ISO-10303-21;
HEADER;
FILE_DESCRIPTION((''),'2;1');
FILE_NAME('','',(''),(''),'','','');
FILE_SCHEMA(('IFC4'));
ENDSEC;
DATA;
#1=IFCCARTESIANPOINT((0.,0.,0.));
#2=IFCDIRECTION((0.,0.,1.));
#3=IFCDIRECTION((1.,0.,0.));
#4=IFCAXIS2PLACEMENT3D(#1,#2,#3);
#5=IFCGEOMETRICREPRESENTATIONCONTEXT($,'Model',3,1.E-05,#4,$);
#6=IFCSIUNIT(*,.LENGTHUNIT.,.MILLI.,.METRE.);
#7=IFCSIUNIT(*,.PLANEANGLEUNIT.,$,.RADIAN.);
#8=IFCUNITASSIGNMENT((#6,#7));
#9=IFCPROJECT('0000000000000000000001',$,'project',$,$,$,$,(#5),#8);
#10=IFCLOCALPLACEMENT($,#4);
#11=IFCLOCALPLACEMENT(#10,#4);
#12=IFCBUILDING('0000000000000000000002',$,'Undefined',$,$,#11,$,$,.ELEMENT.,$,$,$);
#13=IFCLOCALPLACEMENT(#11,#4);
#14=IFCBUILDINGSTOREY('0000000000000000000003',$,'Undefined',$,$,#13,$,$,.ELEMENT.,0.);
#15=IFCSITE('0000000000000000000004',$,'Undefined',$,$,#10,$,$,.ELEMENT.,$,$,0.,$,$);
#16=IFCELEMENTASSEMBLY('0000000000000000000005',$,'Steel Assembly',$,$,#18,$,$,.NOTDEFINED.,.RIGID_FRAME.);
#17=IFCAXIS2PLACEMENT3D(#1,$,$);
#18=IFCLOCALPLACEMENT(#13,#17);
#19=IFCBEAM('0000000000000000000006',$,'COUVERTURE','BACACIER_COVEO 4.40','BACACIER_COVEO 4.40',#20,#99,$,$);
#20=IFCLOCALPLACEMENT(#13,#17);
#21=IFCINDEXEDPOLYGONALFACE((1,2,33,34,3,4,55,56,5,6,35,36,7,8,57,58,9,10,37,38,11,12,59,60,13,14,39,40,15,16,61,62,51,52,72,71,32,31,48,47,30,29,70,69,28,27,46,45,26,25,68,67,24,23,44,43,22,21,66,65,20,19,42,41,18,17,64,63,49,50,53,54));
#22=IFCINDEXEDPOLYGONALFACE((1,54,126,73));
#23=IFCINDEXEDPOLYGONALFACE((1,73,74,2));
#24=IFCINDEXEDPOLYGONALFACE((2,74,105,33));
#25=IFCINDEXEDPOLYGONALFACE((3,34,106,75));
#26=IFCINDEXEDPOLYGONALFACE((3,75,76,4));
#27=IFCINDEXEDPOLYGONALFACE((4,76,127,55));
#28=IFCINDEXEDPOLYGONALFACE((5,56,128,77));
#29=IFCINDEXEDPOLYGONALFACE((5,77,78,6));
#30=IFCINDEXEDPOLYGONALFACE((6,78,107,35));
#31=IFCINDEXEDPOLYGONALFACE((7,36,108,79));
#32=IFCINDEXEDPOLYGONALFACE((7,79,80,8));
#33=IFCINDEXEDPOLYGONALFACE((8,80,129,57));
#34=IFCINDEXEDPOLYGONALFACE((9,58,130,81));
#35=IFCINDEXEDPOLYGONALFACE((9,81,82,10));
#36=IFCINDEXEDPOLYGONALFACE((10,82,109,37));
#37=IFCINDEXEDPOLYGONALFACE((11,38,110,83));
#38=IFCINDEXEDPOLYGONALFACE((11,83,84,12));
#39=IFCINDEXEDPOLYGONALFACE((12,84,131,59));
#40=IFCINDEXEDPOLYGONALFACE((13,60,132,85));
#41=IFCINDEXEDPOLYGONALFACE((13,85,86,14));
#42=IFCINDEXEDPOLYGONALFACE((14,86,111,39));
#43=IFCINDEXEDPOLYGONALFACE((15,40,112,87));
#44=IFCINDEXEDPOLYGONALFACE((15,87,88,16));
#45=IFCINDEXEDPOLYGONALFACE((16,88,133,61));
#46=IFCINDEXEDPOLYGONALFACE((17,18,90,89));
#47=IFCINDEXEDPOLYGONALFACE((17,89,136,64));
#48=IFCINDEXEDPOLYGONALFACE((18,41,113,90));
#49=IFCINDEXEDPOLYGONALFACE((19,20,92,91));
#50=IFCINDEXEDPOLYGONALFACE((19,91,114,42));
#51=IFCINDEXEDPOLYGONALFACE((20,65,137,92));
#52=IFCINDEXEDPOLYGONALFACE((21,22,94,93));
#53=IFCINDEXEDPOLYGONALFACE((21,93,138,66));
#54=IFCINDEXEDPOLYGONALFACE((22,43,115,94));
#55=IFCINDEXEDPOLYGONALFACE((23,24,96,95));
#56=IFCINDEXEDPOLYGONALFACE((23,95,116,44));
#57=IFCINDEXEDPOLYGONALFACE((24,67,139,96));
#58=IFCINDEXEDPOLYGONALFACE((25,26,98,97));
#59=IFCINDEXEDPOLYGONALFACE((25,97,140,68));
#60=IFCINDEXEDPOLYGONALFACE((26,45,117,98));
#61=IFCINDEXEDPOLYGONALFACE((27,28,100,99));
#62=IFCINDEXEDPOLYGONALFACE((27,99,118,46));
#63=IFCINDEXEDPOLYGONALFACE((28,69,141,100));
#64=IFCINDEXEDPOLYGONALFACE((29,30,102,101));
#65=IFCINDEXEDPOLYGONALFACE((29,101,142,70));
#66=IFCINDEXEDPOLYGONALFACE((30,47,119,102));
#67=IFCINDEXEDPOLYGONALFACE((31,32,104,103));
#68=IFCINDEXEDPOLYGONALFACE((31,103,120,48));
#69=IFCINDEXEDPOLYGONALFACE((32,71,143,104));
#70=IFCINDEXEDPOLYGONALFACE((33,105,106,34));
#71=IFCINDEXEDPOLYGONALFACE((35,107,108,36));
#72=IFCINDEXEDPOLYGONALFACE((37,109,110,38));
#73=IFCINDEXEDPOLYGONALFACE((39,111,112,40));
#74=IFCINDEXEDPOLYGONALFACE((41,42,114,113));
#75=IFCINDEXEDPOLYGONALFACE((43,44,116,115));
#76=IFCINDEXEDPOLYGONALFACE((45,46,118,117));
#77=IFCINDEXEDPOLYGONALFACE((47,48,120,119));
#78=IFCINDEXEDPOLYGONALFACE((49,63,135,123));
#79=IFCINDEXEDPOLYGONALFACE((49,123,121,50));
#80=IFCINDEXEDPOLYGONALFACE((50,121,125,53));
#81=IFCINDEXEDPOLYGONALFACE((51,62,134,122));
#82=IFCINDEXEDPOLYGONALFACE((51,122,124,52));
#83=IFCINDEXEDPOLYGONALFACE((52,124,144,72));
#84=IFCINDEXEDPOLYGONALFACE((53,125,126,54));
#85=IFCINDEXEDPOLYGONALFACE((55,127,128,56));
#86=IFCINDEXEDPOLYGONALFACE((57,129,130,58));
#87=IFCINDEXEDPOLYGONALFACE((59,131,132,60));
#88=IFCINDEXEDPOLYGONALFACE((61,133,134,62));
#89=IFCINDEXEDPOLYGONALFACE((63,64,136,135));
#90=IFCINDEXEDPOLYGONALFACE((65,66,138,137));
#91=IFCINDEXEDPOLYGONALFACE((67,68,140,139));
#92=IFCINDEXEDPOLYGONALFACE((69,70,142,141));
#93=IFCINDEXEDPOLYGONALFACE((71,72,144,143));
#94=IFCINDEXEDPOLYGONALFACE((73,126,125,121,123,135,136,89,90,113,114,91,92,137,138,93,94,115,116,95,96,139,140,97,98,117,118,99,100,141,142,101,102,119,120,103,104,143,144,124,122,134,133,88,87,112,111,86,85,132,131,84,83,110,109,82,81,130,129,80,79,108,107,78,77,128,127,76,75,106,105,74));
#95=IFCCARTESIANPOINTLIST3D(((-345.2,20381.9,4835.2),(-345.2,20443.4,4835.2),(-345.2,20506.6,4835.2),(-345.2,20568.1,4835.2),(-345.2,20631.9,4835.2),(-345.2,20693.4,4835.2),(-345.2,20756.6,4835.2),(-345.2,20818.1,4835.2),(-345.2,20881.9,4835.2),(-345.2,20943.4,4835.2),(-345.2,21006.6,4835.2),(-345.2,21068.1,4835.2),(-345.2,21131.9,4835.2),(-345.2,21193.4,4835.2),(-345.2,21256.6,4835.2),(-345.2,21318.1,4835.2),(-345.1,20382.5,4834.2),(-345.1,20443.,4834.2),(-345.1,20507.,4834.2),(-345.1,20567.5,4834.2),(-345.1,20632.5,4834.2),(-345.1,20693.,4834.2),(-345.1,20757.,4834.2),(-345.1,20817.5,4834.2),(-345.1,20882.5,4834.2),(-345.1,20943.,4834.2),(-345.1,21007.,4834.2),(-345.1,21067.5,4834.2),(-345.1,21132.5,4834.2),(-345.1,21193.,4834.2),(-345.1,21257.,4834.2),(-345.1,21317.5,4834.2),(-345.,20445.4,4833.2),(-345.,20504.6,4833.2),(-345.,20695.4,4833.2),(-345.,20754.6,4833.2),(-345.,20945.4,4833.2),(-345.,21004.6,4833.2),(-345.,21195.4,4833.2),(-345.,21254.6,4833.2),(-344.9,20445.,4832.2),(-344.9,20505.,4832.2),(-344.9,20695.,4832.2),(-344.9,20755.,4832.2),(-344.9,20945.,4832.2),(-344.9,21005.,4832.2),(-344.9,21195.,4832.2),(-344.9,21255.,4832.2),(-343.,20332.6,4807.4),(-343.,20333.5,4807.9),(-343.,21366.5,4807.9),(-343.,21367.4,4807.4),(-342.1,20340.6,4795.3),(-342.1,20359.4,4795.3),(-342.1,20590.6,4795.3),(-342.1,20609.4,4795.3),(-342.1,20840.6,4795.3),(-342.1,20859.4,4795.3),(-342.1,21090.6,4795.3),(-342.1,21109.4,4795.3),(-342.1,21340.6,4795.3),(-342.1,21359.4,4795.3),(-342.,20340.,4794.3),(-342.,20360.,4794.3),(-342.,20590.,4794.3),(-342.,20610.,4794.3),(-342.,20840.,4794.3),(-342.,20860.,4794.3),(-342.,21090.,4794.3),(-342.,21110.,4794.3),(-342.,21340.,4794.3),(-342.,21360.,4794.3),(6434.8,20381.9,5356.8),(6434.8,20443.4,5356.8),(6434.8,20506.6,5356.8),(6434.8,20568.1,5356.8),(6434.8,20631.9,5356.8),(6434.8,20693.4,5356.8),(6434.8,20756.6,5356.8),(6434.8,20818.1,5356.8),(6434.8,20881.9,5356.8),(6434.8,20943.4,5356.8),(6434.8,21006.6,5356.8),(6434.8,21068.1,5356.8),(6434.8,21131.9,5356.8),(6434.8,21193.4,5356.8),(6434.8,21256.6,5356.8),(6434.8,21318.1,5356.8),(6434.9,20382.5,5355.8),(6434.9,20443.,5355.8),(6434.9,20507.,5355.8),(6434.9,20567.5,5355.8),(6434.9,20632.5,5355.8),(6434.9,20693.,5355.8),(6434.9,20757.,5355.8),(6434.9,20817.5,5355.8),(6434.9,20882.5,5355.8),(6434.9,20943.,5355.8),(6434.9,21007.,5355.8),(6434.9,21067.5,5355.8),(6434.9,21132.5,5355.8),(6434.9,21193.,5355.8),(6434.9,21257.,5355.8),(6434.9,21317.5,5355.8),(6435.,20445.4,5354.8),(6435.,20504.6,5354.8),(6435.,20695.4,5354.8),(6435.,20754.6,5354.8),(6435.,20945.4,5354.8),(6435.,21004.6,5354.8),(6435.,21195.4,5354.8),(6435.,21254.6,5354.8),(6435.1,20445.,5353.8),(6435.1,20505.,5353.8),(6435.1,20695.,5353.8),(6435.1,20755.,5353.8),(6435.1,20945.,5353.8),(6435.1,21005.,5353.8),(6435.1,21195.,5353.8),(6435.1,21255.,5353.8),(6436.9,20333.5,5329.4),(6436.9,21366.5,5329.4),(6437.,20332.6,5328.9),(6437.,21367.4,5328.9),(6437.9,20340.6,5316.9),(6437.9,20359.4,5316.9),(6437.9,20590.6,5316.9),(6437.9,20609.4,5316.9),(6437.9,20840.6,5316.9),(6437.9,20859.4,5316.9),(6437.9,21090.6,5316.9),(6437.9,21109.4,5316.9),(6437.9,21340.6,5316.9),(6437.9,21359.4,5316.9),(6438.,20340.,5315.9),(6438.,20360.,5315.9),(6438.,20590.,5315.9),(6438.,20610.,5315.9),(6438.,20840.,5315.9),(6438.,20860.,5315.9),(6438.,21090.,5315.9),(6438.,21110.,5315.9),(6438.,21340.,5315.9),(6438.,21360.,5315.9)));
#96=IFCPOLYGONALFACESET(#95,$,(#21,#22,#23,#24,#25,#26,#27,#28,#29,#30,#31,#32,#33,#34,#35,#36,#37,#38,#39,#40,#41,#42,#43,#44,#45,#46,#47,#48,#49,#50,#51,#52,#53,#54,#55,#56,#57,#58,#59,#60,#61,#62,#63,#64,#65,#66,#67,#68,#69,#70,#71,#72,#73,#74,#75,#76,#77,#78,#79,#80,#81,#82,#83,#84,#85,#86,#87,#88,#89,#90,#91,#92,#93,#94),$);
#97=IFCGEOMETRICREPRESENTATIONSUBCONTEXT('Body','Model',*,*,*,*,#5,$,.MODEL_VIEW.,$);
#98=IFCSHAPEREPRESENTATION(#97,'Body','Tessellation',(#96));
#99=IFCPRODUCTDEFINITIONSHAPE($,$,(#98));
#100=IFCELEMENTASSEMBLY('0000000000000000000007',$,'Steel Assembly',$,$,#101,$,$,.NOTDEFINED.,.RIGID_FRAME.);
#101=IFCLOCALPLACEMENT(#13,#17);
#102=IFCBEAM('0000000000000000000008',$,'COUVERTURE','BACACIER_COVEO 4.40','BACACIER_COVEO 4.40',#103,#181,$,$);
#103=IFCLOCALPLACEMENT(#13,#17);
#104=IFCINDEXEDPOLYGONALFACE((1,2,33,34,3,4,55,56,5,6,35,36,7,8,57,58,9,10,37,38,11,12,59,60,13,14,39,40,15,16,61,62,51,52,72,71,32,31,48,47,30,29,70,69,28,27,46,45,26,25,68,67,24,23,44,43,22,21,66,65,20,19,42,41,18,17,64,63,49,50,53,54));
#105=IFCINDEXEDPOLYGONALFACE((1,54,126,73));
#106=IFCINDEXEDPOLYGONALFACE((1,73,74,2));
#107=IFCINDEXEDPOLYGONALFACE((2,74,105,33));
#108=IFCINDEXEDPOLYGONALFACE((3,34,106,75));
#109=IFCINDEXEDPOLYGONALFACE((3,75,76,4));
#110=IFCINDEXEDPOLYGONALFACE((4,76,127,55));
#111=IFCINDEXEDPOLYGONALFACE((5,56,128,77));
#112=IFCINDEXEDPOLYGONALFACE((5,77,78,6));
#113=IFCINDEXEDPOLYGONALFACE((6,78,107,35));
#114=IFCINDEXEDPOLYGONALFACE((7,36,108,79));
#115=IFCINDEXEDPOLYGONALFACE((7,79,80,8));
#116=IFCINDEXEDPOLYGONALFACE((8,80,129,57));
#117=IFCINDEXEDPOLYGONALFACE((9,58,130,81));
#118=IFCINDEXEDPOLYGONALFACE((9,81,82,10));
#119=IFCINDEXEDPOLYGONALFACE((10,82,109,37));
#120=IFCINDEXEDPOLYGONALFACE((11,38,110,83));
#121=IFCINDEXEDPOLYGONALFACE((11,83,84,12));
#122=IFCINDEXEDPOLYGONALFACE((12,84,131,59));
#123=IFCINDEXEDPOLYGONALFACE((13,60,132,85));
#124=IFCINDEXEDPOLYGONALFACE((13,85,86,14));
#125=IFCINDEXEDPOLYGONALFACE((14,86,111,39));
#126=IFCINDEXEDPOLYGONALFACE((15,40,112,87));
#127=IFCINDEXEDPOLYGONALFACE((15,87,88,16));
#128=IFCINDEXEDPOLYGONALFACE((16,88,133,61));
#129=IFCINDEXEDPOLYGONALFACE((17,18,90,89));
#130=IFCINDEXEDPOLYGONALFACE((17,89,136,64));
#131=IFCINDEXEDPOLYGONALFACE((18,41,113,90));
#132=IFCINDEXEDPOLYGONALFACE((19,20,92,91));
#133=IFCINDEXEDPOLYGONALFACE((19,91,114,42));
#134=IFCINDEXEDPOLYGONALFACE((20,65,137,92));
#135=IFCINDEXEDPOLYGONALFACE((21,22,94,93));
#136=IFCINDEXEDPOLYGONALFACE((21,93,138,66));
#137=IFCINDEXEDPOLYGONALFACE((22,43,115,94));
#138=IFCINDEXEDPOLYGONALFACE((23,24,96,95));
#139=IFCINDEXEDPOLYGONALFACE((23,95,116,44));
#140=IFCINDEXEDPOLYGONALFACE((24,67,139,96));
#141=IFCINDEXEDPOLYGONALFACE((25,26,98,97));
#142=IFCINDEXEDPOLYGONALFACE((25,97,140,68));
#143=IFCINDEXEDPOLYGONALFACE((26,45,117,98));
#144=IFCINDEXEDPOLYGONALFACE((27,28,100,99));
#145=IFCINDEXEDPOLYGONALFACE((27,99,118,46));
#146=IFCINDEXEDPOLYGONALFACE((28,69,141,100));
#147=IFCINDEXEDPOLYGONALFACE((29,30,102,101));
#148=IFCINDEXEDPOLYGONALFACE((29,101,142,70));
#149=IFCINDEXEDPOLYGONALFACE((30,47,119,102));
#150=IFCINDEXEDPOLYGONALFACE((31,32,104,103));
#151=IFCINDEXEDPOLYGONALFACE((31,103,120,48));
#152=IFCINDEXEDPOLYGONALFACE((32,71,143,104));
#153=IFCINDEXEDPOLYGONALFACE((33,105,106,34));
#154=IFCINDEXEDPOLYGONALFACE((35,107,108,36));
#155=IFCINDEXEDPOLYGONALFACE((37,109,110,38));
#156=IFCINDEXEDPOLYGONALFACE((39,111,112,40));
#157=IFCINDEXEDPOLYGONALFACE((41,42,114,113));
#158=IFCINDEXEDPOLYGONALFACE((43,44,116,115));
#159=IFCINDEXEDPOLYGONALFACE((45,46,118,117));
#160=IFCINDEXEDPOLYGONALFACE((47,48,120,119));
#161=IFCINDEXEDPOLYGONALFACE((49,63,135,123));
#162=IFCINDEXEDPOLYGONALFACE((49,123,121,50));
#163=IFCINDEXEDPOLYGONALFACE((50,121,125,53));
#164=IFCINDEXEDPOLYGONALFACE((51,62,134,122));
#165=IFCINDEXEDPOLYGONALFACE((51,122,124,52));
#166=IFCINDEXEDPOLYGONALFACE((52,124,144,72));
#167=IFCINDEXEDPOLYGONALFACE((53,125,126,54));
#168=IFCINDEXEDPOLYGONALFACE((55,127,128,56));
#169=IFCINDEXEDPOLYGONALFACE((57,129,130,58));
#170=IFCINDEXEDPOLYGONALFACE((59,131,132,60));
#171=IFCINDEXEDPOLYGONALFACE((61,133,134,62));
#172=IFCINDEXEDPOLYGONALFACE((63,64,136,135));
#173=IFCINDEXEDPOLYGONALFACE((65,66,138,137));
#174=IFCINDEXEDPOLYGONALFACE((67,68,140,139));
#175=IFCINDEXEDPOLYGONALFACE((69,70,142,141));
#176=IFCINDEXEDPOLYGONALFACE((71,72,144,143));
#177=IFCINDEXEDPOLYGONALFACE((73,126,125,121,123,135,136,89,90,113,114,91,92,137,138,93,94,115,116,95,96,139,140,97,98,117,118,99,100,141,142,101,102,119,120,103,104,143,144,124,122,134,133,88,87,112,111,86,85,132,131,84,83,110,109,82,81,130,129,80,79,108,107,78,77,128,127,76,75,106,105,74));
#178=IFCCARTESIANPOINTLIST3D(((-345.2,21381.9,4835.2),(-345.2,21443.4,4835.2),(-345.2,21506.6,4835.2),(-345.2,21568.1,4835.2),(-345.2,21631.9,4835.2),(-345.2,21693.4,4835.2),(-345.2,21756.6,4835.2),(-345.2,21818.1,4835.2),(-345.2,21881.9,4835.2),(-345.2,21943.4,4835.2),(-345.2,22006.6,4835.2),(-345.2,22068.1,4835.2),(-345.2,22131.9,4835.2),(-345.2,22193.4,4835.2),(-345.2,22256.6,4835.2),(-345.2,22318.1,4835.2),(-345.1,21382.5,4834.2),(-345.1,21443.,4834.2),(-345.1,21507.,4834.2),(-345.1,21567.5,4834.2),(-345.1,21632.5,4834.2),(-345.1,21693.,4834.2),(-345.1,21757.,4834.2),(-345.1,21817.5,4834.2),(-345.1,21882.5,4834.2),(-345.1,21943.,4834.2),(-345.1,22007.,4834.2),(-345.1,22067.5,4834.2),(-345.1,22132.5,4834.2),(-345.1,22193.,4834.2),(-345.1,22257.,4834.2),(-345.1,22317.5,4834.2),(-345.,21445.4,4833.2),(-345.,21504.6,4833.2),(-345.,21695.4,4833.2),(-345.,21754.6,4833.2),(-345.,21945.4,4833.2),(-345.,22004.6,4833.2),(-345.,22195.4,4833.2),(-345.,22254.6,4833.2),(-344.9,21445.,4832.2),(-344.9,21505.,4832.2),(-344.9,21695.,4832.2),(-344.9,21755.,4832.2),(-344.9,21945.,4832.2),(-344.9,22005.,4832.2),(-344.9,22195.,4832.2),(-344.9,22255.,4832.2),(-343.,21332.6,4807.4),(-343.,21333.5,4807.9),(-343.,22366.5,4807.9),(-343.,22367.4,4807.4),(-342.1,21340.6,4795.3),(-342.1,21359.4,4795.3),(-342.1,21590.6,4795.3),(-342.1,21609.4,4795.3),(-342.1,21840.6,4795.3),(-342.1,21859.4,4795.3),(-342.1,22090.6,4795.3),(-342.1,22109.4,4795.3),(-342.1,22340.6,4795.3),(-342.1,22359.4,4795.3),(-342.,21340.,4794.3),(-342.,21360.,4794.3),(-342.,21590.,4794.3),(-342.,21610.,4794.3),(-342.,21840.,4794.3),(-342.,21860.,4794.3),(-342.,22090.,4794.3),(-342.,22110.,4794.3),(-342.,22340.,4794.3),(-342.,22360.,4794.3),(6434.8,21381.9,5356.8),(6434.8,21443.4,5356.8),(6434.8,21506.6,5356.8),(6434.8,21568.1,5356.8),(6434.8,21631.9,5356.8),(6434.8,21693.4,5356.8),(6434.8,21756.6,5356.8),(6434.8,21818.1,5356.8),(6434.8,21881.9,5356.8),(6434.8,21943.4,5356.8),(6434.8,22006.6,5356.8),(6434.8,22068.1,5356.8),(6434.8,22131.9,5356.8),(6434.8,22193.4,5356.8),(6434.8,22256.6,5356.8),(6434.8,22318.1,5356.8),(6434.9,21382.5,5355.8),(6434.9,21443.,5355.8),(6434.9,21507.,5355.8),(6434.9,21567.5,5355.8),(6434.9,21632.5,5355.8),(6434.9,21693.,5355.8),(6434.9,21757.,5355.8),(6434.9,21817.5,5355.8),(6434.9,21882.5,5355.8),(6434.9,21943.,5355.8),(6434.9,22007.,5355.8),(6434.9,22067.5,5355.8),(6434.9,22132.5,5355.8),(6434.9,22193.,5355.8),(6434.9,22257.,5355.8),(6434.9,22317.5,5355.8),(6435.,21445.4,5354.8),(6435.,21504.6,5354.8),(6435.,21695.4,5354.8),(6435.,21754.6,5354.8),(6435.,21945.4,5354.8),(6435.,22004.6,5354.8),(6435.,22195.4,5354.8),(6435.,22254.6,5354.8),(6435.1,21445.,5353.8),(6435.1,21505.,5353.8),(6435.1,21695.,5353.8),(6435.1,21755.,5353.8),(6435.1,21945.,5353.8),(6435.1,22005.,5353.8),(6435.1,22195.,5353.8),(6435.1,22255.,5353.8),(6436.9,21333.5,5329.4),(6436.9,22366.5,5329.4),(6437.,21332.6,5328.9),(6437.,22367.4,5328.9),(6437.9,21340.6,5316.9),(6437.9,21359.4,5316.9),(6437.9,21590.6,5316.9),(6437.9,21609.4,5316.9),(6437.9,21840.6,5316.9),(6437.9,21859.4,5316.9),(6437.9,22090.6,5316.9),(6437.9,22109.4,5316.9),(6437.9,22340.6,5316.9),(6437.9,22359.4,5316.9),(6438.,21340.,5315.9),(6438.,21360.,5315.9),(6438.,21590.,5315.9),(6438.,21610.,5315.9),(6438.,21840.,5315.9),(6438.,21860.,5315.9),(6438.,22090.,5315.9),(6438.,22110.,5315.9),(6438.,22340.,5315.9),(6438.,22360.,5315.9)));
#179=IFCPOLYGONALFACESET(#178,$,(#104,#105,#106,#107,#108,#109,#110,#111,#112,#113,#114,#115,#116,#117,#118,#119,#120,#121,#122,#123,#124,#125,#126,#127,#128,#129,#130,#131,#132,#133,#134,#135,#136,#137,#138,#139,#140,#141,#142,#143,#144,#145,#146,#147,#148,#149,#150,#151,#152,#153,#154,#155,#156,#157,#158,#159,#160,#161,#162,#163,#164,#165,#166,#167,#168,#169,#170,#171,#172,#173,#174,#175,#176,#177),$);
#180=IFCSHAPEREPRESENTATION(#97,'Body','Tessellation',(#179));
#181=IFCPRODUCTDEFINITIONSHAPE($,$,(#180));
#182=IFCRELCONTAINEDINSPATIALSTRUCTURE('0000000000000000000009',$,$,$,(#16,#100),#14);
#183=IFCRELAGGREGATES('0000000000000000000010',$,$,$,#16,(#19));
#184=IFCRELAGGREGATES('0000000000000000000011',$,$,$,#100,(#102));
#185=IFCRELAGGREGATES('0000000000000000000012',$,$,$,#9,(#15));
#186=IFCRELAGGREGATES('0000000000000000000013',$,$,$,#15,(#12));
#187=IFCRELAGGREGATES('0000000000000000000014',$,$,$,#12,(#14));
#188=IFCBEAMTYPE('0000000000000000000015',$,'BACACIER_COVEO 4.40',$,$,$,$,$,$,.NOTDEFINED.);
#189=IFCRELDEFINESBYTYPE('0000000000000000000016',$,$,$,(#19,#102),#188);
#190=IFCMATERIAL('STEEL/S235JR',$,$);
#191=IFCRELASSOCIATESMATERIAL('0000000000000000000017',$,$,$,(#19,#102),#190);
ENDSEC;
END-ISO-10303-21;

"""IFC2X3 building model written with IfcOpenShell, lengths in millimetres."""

from ifc_helpers import new_model, si_unit, frame, origin_with_axes, place, context, subcontext, project, spatial, polyline, outline, extrude, material, type_object, element, aggregate, save


model = new_model("IFC2X3")

# Units and contexts
model_context = context("Model", 3, precision=1e-05, world=origin_with_axes())
body_context = subcontext(model_context, "Body", "Model", "MODEL_VIEW")
ifc_project = project(units=[si_unit("LENGTHUNIT", "METRE", prefix="MILLI"), si_unit("PLANEANGLEUNIT", "RADIAN")], contexts=[model_context])

# Site, building, storey
site_placement = place(None, origin_with_axes())
site = spatial("IfcSite", under=ifc_project, at=site_placement, Name="Undefined", CompositionType="ELEMENT", RefElevation=0.0)
building_placement = place(site_placement, origin_with_axes())
building = spatial("IfcBuilding", under=site, at=building_placement, Name="Undefined", CompositionType="ELEMENT")
storey_placement = place(building_placement, origin_with_axes())
storey = spatial("IfcBuildingStorey", under=building, at=storey_placement, Name="Undefined", CompositionType="ELEMENT", Elevation=0.0)

# Element assemblies, beams
ifc_material_1 = material(Name="STEEL/S235JR")
beam_type_1 = type_object("IfcBeamType", Name="BACACIER_COVEO 4.40", PredefinedType="NOTDEFINED")
assembly_1_placement = place(storey_placement, origin_with_axes())
assembly_1 = element("IfcElementAssembly", 1, at=assembly_1_placement, inside=storey, Name="Steel Assembly", AssemblyPlace="NOTDEFINED", PredefinedType="RIGID_FRAME")
beam_1_placement = place(assembly_1_placement, frame((6436.4, 20850.0, 5336.3), z_axis=(0.076696, 0.0, -0.997054), x_axis=(-0.997054, 0.0, -0.076696)))
beam_1 = element("IfcBeam", 2, at=beam_1_placement, type_object=beam_type_1, material=ifc_material_1, Name="COUVERTURE", Description="BACACIER_COVEO 4.40", ObjectType="BACACIER_COVEO 4.40", context=body_context, shape_type="SweptSolid", body=[
    extrude(outline(polyline([(509.4, 19.5), (490.6, 19.5), (468.1, -20.5), (406.6, -20.5), (404.6, -18.5), (345.4, -18.5), (343.4, -20.5), (281.9, -20.5), (259.4, 19.5), (240.6, 19.5), (218.1, -20.5), (156.6, -20.5), (154.6, -18.5), (95.4, -18.5), (93.4, -20.5), (31.9, -20.5), (9.4, 19.5), (-9.4, 19.5), (-31.9, -20.5), (-93.4, -20.5), (-95.4, -18.5), (-154.6, -18.5), (-156.6, -20.5), (-218.1, -20.5), (-240.6, 19.5), (-259.4, 19.5), (-281.9, -20.5), (-343.4, -20.5), (-345.4, -18.5), (-404.6, -18.5), (-406.6, -20.5), (-468.1, -20.5), (-490.6, 19.5), (-509.4, 19.5), (-516.5, 6.9), (-517.4, 7.4), (-510.0, 20.5), (-490.0, 20.5), (-467.5, -19.5), (-407.0, -19.5), (-405.0, -17.5), (-345.0, -17.5), (-343.0, -19.5), (-282.5, -19.5), (-260.0, 20.5), (-240.0, 20.5), (-217.5, -19.5), (-157.0, -19.5), (-155.0, -17.5), (-95.0, -17.5), (-93.0, -19.5), (-32.5, -19.5), (-10.0, 20.5), (10.0, 20.5), (32.5, -19.5), (93.0, -19.5), (95.0, -17.5), (155.0, -17.5), (157.0, -19.5), (217.5, -19.5), (240.0, 20.5), (260.0, 20.5), (282.5, -19.5), (343.0, -19.5), (345.0, -17.5), (405.0, -17.5), (407.0, -19.5), (467.5, -19.5), (490.0, 20.5), (510.0, 20.5), (517.4, 7.4), (516.5, 6.9), (509.4, 19.5)])), frame((6800.0, 0.0, 0.0), z_axis=(-1.0, 0.0, 0.0), x_axis=(0.0, -1.0, 0.0)), (0.0, 0.0, 1.0), 6800.0),
])
aggregate(assembly_1, [beam_1])
assembly_2_placement = place(storey_placement, origin_with_axes())
assembly_2 = element("IfcElementAssembly", 3, at=assembly_2_placement, inside=storey, Name="Steel Assembly", AssemblyPlace="NOTDEFINED", PredefinedType="RIGID_FRAME")
beam_2_placement = place(assembly_2_placement, frame((6436.4, 21850.0, 5336.3), z_axis=(0.076696, 0.0, -0.997054), x_axis=(-0.997054, 0.0, -0.076696)))
beam_2 = element("IfcBeam", 4, at=beam_2_placement, type_object=beam_type_1, material=ifc_material_1, Name="COUVERTURE", Description="BACACIER_COVEO 4.40", ObjectType="BACACIER_COVEO 4.40", context=body_context, shape_type="SweptSolid", body=[
    extrude(outline(polyline([(509.4, 19.5), (490.6, 19.5), (468.1, -20.5), (406.6, -20.5), (404.6, -18.5), (345.4, -18.5), (343.4, -20.5), (281.9, -20.5), (259.4, 19.5), (240.6, 19.5), (218.1, -20.5), (156.6, -20.5), (154.6, -18.5), (95.4, -18.5), (93.4, -20.5), (31.9, -20.5), (9.4, 19.5), (-9.4, 19.5), (-31.9, -20.5), (-93.4, -20.5), (-95.4, -18.5), (-154.6, -18.5), (-156.6, -20.5), (-218.1, -20.5), (-240.6, 19.5), (-259.4, 19.5), (-281.9, -20.5), (-343.4, -20.5), (-345.4, -18.5), (-404.6, -18.5), (-406.6, -20.5), (-468.1, -20.5), (-490.6, 19.5), (-509.4, 19.5), (-516.5, 6.9), (-517.4, 7.4), (-510.0, 20.5), (-490.0, 20.5), (-467.5, -19.5), (-407.0, -19.5), (-405.0, -17.5), (-345.0, -17.5), (-343.0, -19.5), (-282.5, -19.5), (-260.0, 20.5), (-240.0, 20.5), (-217.5, -19.5), (-157.0, -19.5), (-155.0, -17.5), (-95.0, -17.5), (-93.0, -19.5), (-32.5, -19.5), (-10.0, 20.5), (10.0, 20.5), (32.5, -19.5), (93.0, -19.5), (95.0, -17.5), (155.0, -17.5), (157.0, -19.5), (217.5, -19.5), (240.0, 20.5), (260.0, 20.5), (282.5, -19.5), (343.0, -19.5), (345.0, -17.5), (405.0, -17.5), (407.0, -19.5), (467.5, -19.5), (490.0, 20.5), (510.0, 20.5), (517.4, 7.4), (516.5, 6.9), (509.4, 19.5)])), frame((6800.0, 0.0, 0.0), z_axis=(-1.0, 0.0, 0.0), x_axis=(0.0, -1.0, 0.0)), (0.0, 0.0, 1.0), 6800.0),
])
aggregate(assembly_2, [beam_2])

save(model, "model.ifc")
